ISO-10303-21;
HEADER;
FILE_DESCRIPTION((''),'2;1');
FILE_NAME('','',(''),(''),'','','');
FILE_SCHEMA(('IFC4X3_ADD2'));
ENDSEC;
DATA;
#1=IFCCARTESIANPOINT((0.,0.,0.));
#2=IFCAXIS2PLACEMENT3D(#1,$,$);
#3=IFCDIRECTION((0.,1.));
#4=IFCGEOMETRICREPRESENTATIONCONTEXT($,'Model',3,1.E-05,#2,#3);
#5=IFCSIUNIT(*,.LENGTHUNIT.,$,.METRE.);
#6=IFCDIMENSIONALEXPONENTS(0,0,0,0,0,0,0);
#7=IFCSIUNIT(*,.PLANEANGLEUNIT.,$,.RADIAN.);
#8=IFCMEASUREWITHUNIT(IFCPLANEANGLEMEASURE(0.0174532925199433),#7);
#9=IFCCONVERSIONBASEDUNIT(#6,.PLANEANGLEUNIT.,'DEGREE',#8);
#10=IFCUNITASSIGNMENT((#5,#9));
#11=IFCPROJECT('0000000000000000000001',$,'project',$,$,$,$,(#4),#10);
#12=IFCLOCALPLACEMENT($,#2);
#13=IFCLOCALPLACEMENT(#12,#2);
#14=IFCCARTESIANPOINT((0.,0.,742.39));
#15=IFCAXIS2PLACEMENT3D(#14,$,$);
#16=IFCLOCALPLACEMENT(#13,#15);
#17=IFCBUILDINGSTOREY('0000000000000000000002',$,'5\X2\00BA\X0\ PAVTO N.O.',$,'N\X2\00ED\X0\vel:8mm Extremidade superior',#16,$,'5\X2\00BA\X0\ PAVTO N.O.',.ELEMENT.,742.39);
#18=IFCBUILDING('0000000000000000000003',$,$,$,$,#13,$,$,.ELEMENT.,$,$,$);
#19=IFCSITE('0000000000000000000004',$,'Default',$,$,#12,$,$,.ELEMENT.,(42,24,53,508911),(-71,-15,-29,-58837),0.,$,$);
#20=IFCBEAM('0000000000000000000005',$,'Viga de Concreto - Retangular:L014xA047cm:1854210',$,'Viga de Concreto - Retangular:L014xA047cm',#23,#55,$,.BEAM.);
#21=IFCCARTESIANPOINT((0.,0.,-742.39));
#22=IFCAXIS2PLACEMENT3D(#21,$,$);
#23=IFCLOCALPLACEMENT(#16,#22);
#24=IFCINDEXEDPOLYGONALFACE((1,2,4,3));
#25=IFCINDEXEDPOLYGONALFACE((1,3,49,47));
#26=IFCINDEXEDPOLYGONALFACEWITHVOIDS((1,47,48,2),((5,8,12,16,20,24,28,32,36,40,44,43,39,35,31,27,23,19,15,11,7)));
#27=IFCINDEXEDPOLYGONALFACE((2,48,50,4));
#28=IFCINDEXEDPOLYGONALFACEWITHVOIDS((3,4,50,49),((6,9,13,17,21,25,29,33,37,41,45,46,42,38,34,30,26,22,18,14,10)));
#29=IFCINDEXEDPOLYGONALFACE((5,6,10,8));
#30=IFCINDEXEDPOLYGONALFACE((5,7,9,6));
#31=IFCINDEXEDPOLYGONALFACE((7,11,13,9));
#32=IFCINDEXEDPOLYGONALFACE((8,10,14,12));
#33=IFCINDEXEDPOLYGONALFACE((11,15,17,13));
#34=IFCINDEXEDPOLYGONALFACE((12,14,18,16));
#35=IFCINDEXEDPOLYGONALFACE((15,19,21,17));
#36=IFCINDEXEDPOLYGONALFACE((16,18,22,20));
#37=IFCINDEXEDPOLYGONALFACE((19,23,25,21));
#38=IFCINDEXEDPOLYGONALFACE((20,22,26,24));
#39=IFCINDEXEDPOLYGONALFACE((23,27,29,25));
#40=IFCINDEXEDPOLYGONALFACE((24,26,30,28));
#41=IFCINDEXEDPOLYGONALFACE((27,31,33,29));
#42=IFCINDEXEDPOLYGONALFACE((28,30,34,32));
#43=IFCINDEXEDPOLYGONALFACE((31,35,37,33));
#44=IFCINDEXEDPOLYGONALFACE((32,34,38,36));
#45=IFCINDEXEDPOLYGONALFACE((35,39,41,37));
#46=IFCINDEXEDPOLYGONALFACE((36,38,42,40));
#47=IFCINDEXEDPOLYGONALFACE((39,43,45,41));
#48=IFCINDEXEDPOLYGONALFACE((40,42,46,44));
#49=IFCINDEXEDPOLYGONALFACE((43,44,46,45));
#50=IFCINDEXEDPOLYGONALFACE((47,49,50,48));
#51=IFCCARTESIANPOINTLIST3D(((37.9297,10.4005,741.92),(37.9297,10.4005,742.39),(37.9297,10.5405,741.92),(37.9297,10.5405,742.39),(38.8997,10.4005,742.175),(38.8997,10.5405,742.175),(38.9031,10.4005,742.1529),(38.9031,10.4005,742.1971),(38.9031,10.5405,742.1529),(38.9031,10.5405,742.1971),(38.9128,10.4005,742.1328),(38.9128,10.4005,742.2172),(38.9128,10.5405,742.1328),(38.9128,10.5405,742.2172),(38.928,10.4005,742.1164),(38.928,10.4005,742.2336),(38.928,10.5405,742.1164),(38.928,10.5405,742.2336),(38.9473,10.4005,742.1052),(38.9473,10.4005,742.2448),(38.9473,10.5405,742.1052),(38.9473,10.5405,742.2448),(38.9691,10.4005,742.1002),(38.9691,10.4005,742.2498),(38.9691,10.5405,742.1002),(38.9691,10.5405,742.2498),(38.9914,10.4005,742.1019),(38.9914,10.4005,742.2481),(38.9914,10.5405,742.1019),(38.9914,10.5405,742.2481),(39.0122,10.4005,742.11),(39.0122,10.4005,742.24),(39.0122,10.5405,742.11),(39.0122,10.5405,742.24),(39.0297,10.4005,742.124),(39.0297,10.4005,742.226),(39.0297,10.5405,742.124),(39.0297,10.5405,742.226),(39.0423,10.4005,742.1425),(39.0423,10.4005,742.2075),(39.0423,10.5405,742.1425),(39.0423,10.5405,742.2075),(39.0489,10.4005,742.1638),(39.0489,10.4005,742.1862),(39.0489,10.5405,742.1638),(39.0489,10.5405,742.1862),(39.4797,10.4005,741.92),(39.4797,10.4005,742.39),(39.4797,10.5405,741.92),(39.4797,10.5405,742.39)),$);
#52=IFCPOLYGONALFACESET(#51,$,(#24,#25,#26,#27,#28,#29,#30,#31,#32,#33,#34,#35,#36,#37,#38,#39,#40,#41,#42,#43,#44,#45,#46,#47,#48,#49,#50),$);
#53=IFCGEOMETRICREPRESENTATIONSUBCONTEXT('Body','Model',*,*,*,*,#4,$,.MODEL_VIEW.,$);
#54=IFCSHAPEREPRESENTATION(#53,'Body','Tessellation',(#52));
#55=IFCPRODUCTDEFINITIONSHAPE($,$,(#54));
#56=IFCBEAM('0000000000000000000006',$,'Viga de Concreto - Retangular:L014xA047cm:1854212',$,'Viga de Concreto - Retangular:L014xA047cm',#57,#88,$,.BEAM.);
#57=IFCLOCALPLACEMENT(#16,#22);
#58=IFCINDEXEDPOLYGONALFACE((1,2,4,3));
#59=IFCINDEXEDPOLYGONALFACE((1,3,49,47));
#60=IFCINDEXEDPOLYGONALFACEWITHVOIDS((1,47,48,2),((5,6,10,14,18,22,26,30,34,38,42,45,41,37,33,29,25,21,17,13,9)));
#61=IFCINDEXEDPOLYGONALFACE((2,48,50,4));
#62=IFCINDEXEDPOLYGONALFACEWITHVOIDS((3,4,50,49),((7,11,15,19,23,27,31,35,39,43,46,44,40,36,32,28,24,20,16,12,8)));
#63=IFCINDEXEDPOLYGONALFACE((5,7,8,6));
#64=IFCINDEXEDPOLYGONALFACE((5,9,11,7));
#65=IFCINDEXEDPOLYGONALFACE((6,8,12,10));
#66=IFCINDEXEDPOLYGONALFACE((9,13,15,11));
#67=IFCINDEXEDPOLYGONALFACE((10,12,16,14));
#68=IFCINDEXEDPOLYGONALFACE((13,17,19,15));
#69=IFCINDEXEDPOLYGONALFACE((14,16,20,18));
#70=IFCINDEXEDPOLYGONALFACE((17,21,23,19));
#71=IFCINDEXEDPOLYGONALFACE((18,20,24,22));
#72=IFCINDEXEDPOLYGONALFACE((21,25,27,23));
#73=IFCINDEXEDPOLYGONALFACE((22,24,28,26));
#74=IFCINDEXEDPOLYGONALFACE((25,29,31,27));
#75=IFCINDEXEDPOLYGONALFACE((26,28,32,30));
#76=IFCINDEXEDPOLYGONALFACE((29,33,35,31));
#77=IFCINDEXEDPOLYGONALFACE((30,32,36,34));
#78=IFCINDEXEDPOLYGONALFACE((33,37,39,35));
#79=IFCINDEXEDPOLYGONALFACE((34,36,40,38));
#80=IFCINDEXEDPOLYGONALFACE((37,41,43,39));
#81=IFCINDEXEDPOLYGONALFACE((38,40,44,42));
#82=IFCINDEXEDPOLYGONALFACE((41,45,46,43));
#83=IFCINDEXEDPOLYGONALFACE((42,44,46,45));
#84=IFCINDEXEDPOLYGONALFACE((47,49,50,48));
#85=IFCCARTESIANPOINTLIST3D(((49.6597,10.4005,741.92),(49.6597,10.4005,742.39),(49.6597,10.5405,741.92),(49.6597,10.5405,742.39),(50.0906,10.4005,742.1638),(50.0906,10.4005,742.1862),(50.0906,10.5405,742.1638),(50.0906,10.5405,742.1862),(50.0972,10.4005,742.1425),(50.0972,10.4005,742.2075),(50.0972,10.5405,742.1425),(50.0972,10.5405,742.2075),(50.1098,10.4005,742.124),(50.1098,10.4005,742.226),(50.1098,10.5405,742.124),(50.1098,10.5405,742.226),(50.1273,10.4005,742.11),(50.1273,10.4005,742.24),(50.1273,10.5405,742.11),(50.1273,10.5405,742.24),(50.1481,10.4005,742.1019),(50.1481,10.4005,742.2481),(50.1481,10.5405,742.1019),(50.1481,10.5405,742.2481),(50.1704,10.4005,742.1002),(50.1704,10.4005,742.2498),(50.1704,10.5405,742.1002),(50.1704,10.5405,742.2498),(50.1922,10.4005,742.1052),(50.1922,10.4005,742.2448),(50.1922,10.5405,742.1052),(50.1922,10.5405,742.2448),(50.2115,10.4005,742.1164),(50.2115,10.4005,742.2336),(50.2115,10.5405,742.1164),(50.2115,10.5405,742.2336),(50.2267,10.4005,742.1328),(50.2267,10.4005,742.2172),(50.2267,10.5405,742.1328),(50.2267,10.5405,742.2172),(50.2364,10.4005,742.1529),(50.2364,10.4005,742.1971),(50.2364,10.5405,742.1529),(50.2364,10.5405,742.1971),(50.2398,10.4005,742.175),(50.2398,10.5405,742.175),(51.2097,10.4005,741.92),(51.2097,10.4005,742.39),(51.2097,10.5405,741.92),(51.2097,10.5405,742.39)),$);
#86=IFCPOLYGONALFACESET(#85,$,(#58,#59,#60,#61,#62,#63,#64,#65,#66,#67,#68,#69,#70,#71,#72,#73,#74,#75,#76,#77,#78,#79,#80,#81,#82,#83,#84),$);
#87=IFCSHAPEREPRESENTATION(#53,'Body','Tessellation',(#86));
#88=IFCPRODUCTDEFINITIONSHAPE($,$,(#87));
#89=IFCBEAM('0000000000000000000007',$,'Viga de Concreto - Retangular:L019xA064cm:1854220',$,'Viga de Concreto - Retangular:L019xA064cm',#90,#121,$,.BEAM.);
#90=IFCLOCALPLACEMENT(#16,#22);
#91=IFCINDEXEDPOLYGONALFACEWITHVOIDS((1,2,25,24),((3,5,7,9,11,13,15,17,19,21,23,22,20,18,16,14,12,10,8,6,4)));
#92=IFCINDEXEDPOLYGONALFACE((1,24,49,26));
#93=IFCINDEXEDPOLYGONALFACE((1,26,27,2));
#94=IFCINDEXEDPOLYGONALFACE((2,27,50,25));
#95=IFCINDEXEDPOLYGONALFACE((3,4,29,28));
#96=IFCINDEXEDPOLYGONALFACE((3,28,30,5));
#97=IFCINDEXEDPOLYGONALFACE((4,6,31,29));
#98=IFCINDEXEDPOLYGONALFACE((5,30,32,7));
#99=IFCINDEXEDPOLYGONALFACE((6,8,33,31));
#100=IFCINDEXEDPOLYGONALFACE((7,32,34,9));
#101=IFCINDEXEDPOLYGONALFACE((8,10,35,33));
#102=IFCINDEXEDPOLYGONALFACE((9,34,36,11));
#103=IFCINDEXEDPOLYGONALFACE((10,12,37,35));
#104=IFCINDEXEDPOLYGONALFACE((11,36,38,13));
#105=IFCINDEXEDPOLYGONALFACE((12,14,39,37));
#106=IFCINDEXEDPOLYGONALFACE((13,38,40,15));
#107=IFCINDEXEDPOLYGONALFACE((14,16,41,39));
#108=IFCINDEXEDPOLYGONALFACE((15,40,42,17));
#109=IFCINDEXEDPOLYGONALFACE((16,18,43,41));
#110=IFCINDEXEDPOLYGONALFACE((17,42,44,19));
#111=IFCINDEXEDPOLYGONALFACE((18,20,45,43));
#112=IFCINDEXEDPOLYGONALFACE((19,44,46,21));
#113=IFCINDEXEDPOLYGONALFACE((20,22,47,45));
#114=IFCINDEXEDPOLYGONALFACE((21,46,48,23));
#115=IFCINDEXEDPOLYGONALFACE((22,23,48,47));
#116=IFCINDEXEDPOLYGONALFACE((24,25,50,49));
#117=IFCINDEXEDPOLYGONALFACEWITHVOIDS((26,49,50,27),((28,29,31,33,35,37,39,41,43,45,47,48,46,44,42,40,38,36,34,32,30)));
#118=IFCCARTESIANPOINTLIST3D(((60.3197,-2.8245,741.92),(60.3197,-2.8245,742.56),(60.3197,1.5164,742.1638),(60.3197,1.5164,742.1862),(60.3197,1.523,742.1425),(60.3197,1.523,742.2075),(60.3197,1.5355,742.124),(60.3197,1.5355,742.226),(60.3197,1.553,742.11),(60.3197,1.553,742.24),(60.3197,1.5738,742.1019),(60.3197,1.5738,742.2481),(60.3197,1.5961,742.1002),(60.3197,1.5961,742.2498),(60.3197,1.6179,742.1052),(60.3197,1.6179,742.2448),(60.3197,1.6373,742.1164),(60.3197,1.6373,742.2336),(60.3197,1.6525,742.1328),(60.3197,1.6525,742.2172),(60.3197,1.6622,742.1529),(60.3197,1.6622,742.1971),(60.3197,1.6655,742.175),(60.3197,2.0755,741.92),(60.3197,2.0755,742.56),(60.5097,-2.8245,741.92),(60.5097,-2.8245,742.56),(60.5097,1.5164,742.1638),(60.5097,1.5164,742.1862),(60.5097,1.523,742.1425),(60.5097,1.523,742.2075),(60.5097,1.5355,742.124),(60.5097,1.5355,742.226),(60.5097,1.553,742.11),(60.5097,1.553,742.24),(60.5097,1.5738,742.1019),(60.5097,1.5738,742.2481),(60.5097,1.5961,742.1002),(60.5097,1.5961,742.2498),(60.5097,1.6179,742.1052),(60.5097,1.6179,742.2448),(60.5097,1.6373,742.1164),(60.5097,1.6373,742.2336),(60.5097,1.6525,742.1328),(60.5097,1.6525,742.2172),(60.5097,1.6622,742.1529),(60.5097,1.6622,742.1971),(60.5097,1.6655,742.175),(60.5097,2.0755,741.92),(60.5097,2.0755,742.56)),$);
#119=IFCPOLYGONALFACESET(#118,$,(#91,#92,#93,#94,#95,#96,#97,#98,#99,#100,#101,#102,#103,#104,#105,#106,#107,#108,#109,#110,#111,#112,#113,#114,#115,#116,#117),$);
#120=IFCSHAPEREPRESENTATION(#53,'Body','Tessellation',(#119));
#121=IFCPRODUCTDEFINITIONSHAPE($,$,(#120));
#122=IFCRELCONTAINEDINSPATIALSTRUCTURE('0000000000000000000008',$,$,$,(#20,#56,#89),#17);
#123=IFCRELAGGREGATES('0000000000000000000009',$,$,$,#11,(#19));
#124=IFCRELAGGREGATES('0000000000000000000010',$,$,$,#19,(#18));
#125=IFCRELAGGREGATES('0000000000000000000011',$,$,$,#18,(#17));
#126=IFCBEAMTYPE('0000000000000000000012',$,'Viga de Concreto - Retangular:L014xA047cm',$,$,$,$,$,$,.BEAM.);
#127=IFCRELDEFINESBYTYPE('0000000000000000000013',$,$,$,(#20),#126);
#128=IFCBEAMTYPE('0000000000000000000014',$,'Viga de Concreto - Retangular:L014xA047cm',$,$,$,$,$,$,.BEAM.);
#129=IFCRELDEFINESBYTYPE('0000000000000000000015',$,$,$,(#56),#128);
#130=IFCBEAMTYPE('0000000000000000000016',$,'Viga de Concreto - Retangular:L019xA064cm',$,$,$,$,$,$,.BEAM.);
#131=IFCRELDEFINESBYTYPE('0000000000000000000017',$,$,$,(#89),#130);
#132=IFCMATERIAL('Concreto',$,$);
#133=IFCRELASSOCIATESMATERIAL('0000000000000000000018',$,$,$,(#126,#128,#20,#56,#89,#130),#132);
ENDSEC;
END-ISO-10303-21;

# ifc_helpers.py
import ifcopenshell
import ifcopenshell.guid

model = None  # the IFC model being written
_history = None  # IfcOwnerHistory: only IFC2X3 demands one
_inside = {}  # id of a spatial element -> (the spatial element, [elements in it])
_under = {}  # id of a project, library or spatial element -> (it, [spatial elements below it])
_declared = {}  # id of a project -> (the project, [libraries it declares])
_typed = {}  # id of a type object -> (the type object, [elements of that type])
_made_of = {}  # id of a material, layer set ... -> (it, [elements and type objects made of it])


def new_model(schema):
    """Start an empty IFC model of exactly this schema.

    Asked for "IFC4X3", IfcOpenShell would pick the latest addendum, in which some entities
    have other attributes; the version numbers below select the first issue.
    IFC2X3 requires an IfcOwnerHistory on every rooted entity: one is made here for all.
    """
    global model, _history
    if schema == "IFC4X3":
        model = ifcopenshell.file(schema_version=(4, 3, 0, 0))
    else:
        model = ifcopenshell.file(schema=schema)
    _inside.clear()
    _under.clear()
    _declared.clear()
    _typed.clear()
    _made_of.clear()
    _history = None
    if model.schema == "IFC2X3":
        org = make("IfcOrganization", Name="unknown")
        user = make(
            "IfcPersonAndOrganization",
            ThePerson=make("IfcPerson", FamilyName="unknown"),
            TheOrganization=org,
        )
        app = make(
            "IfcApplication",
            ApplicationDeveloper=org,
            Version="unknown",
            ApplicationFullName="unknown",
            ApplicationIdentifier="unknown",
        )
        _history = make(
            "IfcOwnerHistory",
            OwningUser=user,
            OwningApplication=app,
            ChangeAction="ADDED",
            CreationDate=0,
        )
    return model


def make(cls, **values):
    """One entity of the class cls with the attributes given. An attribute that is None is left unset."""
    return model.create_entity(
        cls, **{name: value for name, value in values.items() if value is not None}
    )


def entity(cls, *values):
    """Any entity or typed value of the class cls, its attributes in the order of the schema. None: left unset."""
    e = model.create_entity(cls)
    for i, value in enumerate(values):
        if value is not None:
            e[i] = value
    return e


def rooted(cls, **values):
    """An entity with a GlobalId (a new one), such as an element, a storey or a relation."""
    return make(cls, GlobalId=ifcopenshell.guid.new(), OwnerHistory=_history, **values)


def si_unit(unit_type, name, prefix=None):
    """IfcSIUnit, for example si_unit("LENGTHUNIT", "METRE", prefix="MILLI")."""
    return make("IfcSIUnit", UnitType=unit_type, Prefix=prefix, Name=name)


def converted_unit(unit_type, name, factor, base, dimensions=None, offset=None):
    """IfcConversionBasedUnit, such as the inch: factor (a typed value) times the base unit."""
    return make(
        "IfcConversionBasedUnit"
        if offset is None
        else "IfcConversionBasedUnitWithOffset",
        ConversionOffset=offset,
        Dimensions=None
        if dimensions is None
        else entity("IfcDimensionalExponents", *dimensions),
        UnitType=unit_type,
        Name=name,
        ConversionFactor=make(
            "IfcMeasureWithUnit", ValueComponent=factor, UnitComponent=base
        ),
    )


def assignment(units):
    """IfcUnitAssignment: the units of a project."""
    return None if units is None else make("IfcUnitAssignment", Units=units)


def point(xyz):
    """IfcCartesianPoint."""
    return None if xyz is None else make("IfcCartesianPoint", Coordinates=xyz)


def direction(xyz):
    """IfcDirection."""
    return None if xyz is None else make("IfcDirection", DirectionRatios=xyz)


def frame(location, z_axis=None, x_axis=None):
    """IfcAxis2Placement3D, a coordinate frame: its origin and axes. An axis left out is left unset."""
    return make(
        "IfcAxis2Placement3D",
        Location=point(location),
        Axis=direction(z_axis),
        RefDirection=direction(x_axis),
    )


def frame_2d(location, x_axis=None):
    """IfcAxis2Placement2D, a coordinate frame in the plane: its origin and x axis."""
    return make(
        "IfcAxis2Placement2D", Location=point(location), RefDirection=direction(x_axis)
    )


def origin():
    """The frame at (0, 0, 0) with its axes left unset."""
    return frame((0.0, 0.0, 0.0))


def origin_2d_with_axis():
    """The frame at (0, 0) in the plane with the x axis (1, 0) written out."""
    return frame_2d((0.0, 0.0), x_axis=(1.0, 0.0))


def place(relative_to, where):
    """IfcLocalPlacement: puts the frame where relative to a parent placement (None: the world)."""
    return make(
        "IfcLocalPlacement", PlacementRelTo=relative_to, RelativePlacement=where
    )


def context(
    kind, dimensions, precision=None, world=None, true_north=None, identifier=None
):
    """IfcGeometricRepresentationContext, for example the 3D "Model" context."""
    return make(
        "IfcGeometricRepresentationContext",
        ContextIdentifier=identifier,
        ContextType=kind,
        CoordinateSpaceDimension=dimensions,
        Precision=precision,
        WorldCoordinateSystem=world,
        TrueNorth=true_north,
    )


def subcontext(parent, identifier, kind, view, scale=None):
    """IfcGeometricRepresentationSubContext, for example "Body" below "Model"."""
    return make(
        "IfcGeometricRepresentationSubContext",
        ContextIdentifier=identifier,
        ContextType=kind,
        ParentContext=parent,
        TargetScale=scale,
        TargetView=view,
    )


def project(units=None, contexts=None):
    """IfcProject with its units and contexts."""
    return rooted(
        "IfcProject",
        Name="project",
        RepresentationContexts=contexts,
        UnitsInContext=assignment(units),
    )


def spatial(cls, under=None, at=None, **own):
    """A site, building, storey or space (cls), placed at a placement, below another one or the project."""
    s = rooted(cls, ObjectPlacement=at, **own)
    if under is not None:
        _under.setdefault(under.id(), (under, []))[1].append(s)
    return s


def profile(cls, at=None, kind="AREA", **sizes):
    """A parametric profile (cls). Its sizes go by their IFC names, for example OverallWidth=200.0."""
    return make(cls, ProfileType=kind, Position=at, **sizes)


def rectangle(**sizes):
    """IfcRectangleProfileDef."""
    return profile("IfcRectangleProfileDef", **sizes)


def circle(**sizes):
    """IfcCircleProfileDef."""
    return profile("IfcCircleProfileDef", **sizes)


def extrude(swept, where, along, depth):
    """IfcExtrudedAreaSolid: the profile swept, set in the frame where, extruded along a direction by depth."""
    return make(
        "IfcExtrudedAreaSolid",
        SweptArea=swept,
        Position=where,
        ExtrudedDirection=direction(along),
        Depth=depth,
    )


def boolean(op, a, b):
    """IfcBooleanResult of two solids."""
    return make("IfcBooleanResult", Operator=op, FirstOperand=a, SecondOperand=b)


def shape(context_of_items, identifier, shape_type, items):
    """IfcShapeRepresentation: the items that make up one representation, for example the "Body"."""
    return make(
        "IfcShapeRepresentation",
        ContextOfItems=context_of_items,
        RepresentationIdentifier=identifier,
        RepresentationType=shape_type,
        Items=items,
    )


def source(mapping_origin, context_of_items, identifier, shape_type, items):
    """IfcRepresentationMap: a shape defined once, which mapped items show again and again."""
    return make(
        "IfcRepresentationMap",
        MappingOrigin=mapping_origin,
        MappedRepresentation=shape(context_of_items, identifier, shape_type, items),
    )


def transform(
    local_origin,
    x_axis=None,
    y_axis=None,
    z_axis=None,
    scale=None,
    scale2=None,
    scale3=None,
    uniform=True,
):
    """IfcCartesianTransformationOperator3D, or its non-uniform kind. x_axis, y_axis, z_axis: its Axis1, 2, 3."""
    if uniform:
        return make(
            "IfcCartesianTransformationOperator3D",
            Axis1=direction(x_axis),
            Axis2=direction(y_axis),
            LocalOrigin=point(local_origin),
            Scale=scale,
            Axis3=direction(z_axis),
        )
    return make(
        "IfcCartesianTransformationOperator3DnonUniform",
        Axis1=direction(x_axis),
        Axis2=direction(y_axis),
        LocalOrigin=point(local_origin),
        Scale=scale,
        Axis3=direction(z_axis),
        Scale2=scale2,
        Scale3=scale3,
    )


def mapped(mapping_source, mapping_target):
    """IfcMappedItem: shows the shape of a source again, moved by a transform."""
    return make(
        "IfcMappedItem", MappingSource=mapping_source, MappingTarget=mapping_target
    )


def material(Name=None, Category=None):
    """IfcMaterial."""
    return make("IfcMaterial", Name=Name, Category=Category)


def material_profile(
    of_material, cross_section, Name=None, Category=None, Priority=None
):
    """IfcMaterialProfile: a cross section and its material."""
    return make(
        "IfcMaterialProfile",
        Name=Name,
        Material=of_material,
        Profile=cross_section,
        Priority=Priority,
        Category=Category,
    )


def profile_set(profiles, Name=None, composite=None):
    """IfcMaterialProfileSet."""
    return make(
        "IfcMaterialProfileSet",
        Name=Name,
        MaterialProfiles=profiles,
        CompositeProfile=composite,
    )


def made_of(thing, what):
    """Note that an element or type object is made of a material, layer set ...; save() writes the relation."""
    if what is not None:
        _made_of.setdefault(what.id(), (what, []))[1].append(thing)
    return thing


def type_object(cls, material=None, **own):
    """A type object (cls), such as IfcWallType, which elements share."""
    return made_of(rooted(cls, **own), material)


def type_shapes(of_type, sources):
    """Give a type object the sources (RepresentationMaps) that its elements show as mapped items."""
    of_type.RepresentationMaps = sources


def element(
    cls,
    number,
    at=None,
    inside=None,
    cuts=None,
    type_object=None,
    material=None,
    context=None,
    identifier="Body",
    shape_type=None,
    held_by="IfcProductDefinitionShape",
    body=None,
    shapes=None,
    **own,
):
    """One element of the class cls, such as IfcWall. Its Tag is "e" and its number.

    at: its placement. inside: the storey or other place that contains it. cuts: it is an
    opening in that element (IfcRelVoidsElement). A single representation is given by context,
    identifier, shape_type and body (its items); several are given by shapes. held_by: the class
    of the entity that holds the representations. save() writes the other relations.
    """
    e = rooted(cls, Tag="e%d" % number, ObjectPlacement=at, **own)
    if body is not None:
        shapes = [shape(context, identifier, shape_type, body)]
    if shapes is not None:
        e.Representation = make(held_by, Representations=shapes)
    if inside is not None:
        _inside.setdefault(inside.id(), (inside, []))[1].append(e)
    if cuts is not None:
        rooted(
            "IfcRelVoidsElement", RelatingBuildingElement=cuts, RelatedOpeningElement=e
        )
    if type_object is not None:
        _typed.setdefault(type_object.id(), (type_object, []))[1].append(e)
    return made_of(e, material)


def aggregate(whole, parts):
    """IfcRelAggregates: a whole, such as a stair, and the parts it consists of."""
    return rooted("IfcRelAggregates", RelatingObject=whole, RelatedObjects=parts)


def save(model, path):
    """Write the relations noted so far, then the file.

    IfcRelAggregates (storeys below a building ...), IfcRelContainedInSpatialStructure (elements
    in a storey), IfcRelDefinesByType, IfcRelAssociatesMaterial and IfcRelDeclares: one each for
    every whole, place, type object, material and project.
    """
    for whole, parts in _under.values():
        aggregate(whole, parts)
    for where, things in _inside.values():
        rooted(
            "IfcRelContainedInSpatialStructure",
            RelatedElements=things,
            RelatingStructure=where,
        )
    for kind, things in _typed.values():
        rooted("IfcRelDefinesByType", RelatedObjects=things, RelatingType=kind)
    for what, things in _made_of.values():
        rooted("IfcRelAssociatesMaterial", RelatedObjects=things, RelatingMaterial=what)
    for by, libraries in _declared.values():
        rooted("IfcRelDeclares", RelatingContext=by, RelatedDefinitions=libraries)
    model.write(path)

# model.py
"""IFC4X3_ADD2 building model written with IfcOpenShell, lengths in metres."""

from ifc_helpers import new_model, entity, si_unit, converted_unit, direction, frame, frame_2d, origin, origin_2d_with_axis, place, context, subcontext, project, spatial, rectangle, circle, extrude, boolean, source, transform, mapped, material, material_profile, profile_set, type_object, type_shapes, element, save


model = new_model("IFC4X3_ADD2")

# Units and contexts
model_context = context("Model", 3, precision=1e-05, world=origin(), true_north=direction((0.0, 1.0)))
body_context = subcontext(model_context, "Body", "Model", "MODEL_VIEW")
ifc_project = project(units=[si_unit("LENGTHUNIT", "METRE"), converted_unit("PLANEANGLEUNIT", "DEGREE", entity("IfcPlaneAngleMeasure", 0.0174532925199433), si_unit("PLANEANGLEUNIT", "RADIAN"), dimensions=[0, 0, 0, 0, 0, 0, 0])], contexts=[model_context])

# Site, building, storey
site_placement = place(None, origin())
site = spatial("IfcSite", under=ifc_project, at=site_placement, Name="Default", CompositionType="ELEMENT", RefLatitude=(42, 24, 53, 508911), RefLongitude=(-71, -15, -29, -58837), RefElevation=0.0)
building_placement = place(site_placement, origin())
building = spatial("IfcBuilding", under=site, at=building_placement, CompositionType="ELEMENT")
storey_placement = place(building_placement, frame((0.0, 0.0, 742.39)))
storey = spatial("IfcBuildingStorey", under=building, at=storey_placement, Name="5º PAVTO N.O.", ObjectType="Nível:8mm Extremidade superior", LongName="5º PAVTO N.O.", CompositionType="ELEMENT", Elevation=742.39)

# Shared definitions
ifc_material = material(Name="Concreto")

# Beams
ifc_material_profile_1 = material_profile(ifc_material, rectangle(XDim=0.47, YDim=0.14, at=frame_2d((0.0, 0.0), x_axis=(0.0, 1.0))), Name="L014xA047cm")
ifc_profile_set_1 = profile_set([ifc_material_profile_1], Name="L014xA047cm")
beam_type_1 = type_object("IfcBeamType", Name="Viga de Concreto - Retangular:L014xA047cm", PredefinedType="BEAM", material=ifc_profile_set_1)
shared_shape_1 = source(origin(), body_context, "Body", "CSG", [
    boolean("DIFFERENCE", extrude(rectangle(XDim=0.47, YDim=0.14, at=frame_2d((0.0, 0.0), x_axis=(0.0, 1.0))), frame((37.9297, 10.4705, 742.155), z_axis=(1.0, 0.0, 0.0), x_axis=(0.0, 1.0, 0.0)), (0.0, 0.0, 1.0), 1.55), extrude(circle(Radius=0.075, at=frame_2d((0.0, 0.0), x_axis=(1.0, 0.0))), frame((38.9747, 10.5405, 742.175), z_axis=(0.0, -1.0, 0.0), x_axis=(-1.0, 0.0, 0.0)), (0.0, 0.0, 1.0), 0.14)),
])
type_shapes(beam_type_1, [shared_shape_1])
beam_1_placement = place(storey_placement, frame((0.0, 0.0, -742.39)))
element("IfcBeam", 1, at=beam_1_placement, inside=storey, type_object=beam_type_1, material=ifc_material, Name="Viga de Concreto - Retangular:L014xA047cm:1854210", ObjectType="Viga de Concreto - Retangular:L014xA047cm", PredefinedType="BEAM", context=body_context, shape_type="MappedRepresentation", body=[
    mapped(shared_shape_1, transform((0.0, 0.0, 0.0), scale=1.0)),
])
beam_type_2 = type_object("IfcBeamType", Name="Viga de Concreto - Retangular:L014xA047cm", PredefinedType="BEAM", material=ifc_profile_set_1)
shared_shape_2 = source(origin(), body_context, "Body", "CSG", [
    boolean("DIFFERENCE", extrude(rectangle(XDim=0.47, YDim=0.14, at=frame_2d((0.0, 0.0), x_axis=(0.0, 1.0))), frame((49.6597, 10.4705, 742.155), z_axis=(1.0, 0.0, 0.0), x_axis=(0.0, 1.0, 0.0)), (0.0, 0.0, 1.0), 1.55), extrude(circle(Radius=0.075, at=frame_2d((0.0, 0.0), x_axis=(1.0, 0.0))), frame((50.1648, 10.4005, 742.175), z_axis=(0.0, 1.0, 0.0), x_axis=(1.0, 0.0, 0.0)), (0.0, 0.0, 1.0), 0.14)),
])
type_shapes(beam_type_2, [shared_shape_2])
beam_2_placement = place(storey_placement, frame((0.0, 0.0, -742.39)))
element("IfcBeam", 2, at=beam_2_placement, inside=storey, type_object=beam_type_2, material=ifc_material, Name="Viga de Concreto - Retangular:L014xA047cm:1854212", ObjectType="Viga de Concreto - Retangular:L014xA047cm", PredefinedType="BEAM", context=body_context, shape_type="MappedRepresentation", body=[
    mapped(shared_shape_2, transform((0.0, 0.0, 0.0), scale=1.0)),
])
ifc_material_profile_2 = material_profile(ifc_material, rectangle(XDim=0.64, YDim=0.19, at=frame_2d((0.0, 0.0), x_axis=(1.0, 0.0))), Name="L019xA064cm")
ifc_profile_set_2 = profile_set([ifc_material_profile_2], Name="L019xA064cm")
beam_type_3 = type_object("IfcBeamType", Name="Viga de Concreto - Retangular:L019xA064cm", PredefinedType="BEAM", material=ifc_profile_set_2)
shared_shape_3 = source(origin(), body_context, "Body", "CSG", [
    boolean("DIFFERENCE", extrude(rectangle(XDim=0.64, YDim=0.19, at=frame_2d((0.0, 0.0), x_axis=(0.0, 1.0))), frame((60.4147, 2.0755, 742.24), z_axis=(0.0, -1.0, 0.0), x_axis=(-1.0, 0.0, 0.0)), (0.0, 0.0, 1.0), 4.9), extrude(circle(Radius=0.075, at=origin_2d_with_axis()), frame((60.5097, 1.5905, 742.175), z_axis=(-1.0, 0.0, 0.0), x_axis=(0.0, 1.0, 0.0)), (0.0, 0.0, 1.0), 0.19)),
])
type_shapes(beam_type_3, [shared_shape_3])
beam_3_placement = place(storey_placement, frame((0.0, 0.0, -742.39)))
element("IfcBeam", 3, at=beam_3_placement, inside=storey, type_object=beam_type_3, material=ifc_material, Name="Viga de Concreto - Retangular:L019xA064cm:1854220", ObjectType="Viga de Concreto - Retangular:L019xA064cm", PredefinedType="BEAM", context=body_context, shape_type="MappedRepresentation", body=[
    mapped(shared_shape_3, transform((0.0, 0.0, 0.0), scale=1.0)),
])

save(model, "model.ifc")
